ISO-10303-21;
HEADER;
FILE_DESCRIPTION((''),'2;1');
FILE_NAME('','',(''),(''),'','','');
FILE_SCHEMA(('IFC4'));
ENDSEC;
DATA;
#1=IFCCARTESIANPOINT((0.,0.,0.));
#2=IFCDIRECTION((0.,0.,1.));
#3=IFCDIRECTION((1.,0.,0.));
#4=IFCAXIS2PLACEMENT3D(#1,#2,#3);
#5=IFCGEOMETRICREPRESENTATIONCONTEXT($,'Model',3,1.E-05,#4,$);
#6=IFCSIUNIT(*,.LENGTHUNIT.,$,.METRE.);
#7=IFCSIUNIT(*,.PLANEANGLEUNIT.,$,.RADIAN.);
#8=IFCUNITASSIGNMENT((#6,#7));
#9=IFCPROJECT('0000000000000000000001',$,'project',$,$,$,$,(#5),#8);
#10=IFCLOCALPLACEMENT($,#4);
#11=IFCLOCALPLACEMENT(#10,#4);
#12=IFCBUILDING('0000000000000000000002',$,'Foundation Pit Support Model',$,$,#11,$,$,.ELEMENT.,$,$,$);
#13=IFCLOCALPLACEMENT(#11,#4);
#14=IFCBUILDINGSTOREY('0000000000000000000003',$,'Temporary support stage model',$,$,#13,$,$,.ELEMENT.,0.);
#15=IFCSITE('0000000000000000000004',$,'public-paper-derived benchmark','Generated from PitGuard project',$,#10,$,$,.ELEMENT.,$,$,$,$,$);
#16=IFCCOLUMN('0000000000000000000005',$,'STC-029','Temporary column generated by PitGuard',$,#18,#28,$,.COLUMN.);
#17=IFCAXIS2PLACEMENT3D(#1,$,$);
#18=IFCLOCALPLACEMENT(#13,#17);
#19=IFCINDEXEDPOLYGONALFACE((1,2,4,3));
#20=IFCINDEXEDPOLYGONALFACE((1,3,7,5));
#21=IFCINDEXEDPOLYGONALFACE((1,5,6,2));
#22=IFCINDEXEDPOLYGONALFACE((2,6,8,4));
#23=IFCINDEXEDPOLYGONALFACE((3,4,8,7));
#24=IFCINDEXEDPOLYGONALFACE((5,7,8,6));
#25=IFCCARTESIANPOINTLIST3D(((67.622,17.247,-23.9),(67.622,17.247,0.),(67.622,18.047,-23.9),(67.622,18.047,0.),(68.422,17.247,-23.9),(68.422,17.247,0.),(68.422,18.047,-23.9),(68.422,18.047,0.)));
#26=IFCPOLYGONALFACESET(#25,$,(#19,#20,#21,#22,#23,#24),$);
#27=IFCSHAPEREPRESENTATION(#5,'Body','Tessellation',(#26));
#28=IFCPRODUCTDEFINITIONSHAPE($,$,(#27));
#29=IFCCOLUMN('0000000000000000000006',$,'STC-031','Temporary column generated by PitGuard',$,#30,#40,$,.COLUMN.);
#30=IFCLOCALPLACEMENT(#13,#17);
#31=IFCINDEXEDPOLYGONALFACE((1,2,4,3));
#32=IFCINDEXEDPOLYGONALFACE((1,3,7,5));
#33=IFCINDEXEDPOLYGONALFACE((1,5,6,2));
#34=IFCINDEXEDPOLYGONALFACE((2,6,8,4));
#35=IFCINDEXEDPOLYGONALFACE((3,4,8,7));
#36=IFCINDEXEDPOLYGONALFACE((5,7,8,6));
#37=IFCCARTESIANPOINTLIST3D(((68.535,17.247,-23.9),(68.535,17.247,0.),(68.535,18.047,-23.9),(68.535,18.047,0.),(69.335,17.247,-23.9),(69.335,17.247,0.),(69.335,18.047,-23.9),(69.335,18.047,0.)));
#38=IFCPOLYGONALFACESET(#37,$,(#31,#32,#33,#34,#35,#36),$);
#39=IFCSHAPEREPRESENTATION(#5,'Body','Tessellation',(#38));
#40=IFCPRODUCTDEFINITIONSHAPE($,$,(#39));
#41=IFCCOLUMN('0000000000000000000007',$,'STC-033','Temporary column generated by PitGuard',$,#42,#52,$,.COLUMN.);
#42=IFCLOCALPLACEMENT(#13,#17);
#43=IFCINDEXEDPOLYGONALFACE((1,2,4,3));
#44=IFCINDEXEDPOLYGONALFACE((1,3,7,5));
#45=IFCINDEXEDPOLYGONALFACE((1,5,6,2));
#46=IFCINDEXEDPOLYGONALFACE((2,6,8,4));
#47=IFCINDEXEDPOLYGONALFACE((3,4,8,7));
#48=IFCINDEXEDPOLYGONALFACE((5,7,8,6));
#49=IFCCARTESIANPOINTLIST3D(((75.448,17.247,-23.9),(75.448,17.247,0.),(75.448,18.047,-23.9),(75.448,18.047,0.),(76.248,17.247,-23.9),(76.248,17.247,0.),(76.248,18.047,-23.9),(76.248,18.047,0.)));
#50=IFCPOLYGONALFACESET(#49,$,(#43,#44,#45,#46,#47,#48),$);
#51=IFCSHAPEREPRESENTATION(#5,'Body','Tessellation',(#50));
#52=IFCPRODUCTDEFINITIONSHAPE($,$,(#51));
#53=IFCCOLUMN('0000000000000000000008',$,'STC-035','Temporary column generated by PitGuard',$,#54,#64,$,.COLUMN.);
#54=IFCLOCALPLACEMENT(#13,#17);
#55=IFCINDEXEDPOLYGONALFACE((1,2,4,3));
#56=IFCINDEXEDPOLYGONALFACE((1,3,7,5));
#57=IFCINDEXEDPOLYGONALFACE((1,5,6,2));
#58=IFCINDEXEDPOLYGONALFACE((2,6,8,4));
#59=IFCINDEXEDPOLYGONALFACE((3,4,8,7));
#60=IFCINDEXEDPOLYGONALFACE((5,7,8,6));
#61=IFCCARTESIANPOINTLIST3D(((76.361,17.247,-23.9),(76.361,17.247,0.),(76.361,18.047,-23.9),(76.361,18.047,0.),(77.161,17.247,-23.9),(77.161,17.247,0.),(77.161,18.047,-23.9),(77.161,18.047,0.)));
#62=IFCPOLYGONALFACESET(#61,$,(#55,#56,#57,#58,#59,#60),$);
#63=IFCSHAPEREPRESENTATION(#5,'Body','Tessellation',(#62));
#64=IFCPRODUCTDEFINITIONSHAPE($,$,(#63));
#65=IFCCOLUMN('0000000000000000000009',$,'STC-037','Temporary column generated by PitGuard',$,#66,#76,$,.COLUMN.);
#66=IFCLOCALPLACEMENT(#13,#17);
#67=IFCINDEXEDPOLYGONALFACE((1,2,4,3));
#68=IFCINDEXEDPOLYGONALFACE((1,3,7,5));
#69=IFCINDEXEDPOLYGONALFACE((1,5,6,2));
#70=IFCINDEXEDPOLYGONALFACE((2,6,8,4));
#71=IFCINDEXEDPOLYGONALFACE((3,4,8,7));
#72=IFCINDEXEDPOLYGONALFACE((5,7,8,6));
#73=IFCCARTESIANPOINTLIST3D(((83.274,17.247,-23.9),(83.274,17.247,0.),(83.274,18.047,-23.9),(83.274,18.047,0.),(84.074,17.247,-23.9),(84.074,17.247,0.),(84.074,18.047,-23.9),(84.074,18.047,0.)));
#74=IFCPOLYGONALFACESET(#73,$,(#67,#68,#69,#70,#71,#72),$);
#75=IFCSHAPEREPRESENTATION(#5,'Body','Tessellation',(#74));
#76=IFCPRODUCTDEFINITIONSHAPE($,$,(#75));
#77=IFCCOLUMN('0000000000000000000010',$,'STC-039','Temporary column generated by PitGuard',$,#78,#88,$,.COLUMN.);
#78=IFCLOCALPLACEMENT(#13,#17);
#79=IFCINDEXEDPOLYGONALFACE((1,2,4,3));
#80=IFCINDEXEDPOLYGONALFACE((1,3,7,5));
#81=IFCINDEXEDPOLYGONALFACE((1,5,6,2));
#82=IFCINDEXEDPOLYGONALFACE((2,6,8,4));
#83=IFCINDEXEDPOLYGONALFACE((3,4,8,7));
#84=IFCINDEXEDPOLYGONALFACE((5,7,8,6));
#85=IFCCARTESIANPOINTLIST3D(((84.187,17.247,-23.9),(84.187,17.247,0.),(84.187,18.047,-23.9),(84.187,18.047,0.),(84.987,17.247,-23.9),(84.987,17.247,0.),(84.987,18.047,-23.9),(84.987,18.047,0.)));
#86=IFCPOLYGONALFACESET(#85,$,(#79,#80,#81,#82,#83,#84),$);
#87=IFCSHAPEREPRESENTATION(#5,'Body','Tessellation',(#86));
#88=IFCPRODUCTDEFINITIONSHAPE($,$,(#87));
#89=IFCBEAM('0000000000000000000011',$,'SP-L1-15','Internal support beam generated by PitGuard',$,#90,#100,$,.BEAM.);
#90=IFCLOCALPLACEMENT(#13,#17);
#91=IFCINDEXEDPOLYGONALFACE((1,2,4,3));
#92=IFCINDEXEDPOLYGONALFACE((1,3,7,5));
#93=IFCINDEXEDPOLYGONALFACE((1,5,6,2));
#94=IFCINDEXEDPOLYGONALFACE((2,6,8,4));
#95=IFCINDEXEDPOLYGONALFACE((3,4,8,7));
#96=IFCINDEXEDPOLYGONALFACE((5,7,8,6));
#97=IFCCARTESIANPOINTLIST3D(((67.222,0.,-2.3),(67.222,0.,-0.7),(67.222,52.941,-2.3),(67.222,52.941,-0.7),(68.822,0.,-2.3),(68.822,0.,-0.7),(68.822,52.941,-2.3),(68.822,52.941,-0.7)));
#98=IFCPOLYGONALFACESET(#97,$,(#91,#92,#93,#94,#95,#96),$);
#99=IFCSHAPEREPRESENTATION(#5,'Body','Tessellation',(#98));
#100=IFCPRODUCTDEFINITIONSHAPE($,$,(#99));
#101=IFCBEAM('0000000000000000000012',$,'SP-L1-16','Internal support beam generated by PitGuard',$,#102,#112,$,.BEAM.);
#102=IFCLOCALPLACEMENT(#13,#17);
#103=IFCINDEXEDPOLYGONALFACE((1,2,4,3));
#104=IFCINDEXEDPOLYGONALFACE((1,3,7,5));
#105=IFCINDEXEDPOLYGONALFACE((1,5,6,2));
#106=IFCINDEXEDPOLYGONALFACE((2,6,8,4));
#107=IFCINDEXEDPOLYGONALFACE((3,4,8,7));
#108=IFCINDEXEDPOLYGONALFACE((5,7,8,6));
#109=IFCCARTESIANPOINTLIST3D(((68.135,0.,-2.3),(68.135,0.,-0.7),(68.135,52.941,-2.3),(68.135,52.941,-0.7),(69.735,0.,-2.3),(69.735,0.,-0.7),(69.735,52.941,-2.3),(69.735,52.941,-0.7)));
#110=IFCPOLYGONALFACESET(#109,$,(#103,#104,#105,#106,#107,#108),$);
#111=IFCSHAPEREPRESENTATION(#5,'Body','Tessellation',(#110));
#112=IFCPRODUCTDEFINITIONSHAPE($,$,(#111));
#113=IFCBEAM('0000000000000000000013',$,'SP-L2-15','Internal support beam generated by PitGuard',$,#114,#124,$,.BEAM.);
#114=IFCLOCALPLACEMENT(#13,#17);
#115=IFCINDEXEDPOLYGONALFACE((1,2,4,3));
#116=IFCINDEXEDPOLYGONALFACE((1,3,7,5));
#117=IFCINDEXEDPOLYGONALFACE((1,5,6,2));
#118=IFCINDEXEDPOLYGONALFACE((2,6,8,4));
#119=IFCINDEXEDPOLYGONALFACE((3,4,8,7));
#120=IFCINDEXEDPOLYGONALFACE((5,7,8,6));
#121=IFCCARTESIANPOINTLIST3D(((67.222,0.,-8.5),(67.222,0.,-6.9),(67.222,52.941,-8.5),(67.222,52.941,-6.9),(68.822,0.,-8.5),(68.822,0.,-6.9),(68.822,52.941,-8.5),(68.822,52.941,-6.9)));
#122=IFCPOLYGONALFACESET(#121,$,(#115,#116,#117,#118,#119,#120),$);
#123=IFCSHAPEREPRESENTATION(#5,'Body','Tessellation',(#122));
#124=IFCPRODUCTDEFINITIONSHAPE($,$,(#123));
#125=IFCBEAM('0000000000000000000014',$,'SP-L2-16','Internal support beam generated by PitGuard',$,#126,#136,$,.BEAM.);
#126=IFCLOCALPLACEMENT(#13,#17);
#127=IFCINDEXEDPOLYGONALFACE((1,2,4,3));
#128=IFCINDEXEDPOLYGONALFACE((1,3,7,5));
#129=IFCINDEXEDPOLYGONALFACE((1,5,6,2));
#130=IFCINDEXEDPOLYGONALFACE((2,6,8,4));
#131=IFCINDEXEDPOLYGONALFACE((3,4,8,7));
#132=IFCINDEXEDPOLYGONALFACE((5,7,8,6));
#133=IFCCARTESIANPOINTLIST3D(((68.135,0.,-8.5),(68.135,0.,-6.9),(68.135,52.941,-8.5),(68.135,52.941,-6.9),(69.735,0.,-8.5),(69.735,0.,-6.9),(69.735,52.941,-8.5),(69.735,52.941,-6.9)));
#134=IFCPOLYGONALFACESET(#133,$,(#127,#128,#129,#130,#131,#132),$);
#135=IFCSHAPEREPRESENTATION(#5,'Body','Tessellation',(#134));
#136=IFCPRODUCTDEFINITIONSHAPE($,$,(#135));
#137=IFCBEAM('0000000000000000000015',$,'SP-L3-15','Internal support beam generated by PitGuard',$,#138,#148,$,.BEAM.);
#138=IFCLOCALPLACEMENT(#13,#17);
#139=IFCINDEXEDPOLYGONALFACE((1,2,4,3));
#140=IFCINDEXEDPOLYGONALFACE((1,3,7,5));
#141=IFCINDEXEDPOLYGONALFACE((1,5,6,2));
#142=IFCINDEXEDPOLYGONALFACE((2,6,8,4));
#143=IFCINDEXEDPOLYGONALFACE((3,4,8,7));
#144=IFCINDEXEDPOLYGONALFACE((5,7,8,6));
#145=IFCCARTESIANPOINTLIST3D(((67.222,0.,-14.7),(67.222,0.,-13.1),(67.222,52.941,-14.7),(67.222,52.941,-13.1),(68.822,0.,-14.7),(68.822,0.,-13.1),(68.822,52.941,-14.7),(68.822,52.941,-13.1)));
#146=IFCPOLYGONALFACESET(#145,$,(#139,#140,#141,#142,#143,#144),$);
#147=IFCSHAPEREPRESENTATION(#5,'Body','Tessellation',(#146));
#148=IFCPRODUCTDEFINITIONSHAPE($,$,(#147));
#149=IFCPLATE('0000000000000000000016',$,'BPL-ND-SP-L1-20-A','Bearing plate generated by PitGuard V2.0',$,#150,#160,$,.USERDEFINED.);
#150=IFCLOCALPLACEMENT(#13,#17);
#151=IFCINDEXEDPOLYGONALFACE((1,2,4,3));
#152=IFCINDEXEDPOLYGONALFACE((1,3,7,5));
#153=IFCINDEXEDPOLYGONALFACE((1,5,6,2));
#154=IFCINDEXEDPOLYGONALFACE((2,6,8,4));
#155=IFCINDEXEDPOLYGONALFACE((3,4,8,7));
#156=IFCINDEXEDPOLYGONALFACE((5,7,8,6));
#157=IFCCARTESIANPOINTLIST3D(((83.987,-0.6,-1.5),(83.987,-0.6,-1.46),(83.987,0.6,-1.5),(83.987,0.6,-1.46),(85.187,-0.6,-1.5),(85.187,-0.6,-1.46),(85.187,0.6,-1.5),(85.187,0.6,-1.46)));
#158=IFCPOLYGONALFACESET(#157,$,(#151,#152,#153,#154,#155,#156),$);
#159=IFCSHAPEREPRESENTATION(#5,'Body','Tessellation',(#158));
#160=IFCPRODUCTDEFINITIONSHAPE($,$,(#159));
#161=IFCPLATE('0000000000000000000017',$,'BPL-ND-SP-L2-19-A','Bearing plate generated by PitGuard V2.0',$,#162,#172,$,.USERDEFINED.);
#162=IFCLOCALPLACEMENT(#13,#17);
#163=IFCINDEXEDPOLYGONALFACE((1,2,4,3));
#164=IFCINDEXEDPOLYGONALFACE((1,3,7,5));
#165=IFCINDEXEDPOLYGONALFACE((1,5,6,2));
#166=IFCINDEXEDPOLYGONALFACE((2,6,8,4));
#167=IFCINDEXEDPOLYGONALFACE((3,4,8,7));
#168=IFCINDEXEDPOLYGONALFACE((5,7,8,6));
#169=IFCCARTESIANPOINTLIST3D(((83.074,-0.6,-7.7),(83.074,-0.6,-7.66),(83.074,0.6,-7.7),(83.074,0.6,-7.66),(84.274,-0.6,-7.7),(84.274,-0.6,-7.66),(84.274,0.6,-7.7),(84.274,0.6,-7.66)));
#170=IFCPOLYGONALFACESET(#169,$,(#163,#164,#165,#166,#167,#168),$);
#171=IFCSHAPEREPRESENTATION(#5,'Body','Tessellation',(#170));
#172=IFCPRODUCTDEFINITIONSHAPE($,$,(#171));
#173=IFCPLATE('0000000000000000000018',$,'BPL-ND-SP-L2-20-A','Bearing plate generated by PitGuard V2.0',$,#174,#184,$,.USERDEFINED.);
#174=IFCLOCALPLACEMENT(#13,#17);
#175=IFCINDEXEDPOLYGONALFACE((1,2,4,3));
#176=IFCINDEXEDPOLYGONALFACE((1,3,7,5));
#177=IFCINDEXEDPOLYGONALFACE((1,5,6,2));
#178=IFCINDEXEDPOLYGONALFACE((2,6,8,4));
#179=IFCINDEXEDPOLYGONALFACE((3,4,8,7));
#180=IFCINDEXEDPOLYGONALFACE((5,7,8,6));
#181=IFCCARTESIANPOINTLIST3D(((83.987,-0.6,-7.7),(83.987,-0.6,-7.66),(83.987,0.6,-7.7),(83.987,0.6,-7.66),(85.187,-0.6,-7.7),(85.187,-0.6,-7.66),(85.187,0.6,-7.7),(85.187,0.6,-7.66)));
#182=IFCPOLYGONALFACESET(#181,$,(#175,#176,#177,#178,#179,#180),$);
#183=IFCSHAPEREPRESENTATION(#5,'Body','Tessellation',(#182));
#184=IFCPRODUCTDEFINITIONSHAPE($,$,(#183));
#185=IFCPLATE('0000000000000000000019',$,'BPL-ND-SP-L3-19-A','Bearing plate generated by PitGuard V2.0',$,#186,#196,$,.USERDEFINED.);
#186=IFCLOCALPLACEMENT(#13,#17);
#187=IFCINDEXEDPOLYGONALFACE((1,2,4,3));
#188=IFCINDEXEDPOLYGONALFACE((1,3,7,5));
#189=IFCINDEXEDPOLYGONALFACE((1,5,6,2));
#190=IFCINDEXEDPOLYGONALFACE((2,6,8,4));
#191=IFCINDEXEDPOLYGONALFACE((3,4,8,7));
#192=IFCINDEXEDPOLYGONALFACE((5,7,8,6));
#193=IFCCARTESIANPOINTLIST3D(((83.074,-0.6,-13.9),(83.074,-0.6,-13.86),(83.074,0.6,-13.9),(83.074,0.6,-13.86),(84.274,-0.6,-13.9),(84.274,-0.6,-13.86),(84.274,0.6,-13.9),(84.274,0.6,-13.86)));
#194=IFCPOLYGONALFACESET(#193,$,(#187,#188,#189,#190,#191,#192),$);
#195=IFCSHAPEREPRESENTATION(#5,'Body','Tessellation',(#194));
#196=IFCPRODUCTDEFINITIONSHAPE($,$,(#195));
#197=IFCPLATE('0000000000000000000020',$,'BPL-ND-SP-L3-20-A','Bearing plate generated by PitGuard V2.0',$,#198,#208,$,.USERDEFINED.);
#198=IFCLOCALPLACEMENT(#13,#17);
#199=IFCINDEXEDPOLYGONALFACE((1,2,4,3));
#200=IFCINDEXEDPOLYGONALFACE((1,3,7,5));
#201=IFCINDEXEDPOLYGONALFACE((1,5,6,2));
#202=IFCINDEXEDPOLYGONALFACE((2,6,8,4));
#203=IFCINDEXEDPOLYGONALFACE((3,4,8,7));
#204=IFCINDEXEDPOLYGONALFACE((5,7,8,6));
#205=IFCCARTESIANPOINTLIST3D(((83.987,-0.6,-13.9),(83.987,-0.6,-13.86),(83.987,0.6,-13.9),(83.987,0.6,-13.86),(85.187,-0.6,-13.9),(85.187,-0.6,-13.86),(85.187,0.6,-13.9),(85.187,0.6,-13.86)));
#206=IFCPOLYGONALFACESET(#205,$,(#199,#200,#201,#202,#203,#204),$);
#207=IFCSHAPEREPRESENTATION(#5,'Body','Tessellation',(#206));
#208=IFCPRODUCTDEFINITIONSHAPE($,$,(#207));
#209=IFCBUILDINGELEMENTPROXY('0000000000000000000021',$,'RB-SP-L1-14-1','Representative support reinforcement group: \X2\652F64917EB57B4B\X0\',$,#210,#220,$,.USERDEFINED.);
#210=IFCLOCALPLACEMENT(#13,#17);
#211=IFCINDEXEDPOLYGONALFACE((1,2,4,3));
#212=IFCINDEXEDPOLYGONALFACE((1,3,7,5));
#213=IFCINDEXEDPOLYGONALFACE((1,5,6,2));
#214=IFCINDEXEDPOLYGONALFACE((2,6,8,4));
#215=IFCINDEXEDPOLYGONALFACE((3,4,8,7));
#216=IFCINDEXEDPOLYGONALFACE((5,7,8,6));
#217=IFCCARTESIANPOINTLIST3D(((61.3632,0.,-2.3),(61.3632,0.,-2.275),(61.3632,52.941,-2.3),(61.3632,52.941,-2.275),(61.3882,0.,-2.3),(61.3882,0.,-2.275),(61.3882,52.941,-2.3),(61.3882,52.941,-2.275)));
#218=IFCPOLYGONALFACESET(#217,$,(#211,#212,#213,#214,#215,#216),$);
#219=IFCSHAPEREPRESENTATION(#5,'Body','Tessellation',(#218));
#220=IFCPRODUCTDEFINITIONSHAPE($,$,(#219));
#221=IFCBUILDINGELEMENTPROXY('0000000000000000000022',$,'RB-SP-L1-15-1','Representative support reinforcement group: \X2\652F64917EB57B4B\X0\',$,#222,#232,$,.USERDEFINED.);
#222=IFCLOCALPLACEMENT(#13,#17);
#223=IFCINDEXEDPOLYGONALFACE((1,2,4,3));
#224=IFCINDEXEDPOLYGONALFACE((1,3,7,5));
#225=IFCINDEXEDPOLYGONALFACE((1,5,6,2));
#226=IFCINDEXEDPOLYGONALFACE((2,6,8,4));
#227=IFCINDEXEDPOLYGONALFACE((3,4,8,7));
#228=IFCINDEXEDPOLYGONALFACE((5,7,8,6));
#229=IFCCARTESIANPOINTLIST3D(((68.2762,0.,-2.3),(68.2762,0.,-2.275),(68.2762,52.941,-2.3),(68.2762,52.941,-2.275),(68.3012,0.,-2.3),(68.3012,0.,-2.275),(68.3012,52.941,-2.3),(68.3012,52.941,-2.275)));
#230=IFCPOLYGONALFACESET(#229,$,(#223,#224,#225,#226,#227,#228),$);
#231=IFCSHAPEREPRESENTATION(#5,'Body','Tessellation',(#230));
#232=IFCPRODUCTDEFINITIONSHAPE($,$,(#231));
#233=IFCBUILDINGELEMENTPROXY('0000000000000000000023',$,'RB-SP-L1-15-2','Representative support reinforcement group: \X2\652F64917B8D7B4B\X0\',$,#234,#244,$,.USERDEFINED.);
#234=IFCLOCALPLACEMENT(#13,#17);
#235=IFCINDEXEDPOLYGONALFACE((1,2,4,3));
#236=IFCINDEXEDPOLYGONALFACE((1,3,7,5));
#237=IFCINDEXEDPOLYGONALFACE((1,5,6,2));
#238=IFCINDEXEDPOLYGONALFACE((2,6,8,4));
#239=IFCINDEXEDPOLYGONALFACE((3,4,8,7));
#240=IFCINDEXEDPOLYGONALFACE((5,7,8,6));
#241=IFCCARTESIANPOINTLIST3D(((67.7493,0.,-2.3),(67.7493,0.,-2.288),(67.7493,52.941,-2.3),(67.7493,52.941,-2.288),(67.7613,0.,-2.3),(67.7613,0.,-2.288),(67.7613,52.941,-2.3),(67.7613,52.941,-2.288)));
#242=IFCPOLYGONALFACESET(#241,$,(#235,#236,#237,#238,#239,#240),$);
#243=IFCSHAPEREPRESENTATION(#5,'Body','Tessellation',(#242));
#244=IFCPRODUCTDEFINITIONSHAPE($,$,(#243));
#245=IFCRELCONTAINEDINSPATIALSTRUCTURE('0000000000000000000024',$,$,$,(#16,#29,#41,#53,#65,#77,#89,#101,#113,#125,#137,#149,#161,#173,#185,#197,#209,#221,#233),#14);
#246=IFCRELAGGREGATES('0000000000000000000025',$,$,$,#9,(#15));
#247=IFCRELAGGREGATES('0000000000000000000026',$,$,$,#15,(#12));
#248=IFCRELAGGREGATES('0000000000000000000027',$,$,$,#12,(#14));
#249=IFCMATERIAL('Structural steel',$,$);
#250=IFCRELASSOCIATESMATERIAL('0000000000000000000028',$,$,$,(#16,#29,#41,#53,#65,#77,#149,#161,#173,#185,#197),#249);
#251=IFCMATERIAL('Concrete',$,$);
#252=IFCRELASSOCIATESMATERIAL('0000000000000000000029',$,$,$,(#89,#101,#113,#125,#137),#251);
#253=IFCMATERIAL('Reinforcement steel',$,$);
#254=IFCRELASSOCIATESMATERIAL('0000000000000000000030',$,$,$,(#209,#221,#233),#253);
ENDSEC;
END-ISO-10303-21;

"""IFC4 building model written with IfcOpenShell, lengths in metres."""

from ifc_helpers import new_model, si_unit, frame, origin_with_axes, origin_2d, place, context, project, spatial, rectangle, extrude, material, element, save


model = new_model("IFC4")

# Units and contexts
model_context = context("Model", 3, precision=1e-05, world=origin_with_axes())
ifc_project = project(units=[si_unit("LENGTHUNIT", "METRE"), si_unit("PLANEANGLEUNIT", "RADIAN")], contexts=[model_context])

# Site, building, storey
site_placement = place(None, origin_with_axes())
site = spatial("IfcSite", under=ifc_project, at=site_placement, Name="public-paper-derived benchmark", Description="Generated from PitGuard project", CompositionType="ELEMENT")
building_placement = place(site_placement, origin_with_axes())
building = spatial("IfcBuilding", under=site, at=building_placement, Name="Foundation Pit Support Model", CompositionType="ELEMENT")
storey_placement = place(building_placement, origin_with_axes())
storey = spatial("IfcBuildingStorey", under=building, at=storey_placement, Name="Temporary support stage model", CompositionType="ELEMENT", Elevation=0.0)

# Columns
ifc_material_1 = material(Name="Structural steel")
for number, where, z_axis, x_axis, name in (
    (1, (68.022, 17.647, -23.9), (0.0, 0.0, 1.0), (1.0, 0.0, 0.0), "STC-029"),
    (2, (68.935, 17.647, -23.9), (0.0, 0.0, 1.0), (1.0, 0.0, 0.0), "STC-031"),
    (3, (75.848, 17.647, -23.9), (0.0, 0.0, 1.0), (1.0, 0.0, 0.0), "STC-033"),
    (4, (76.761, 17.647, -23.9), (0.0, 0.0, 1.0), (1.0, 0.0, 0.0), "STC-035"),
    (5, (83.674, 17.647, -23.9), (0.0, 0.0, 1.0), (1.0, 0.0, 0.0), "STC-037"),
    (6, (84.587, 17.647, -23.9), (0.0, 0.0, 1.0), (1.0, 0.0, 0.0), "STC-039"),
):
    element("IfcColumn", number, at=place(storey_placement, frame(where, z_axis=z_axis, x_axis=x_axis)), inside=storey, material=ifc_material_1, Name=name, Description="Temporary column generated by PitGuard", PredefinedType="COLUMN", context=model_context, shape_type="SweptSolid", body=[
        extrude(rectangle(XDim=0.8, YDim=0.8, at=origin_2d()), origin_with_axes(), (0.0, 0.0, 1.0), 23.9),
    ])

# Beams
ifc_material_2 = material(Name="Concrete")
for number, where, z_axis, x_axis, name in (
    (7, (68.022, 26.4705, -2.3), (0.0, 0.0, 1.0), (0.0, 1.0, 0.0), "SP-L1-15"),
    (8, (68.935, 26.4705, -2.3), (0.0, 0.0, 1.0), (0.0, 1.0, 0.0), "SP-L1-16"),
    (9, (68.022, 26.4705, -8.5), (0.0, 0.0, 1.0), (0.0, 1.0, 0.0), "SP-L2-15"),
    (10, (68.935, 26.4705, -8.5), (0.0, 0.0, 1.0), (0.0, 1.0, 0.0), "SP-L2-16"),
    (11, (68.022, 26.4705, -14.7), (0.0, 0.0, 1.0), (0.0, 1.0, 0.0), "SP-L3-15"),
):
    element("IfcBeam", number, at=place(storey_placement, frame(where, z_axis=z_axis, x_axis=x_axis)), inside=storey, material=ifc_material_2, Name=name, Description="Internal support beam generated by PitGuard", PredefinedType="BEAM", context=model_context, shape_type="SweptSolid", body=[
        extrude(rectangle(XDim=52.941, YDim=1.6, at=origin_2d()), origin_with_axes(), (0.0, 0.0, 1.0), 1.6),
    ])

# Plates
for number, where, z_axis, x_axis, name in (
    (12, (84.587, 0.0, -1.5), (0.0, 0.0, 1.0), (1.0, 0.0, 0.0), "BPL-ND-SP-L1-20-A"),
    (13, (83.674, 0.0, -7.7), (0.0, 0.0, 1.0), (1.0, 0.0, 0.0), "BPL-ND-SP-L2-19-A"),
    (14, (84.587, 0.0, -7.7), (0.0, 0.0, 1.0), (1.0, 0.0, 0.0), "BPL-ND-SP-L2-20-A"),
    (15, (83.674, 0.0, -13.9), (0.0, 0.0, 1.0), (1.0, 0.0, 0.0), "BPL-ND-SP-L3-19-A"),
    (16, (84.587, 0.0, -13.9), (0.0, 0.0, 1.0), (1.0, 0.0, 0.0), "BPL-ND-SP-L3-20-A"),
):
    element("IfcPlate", number, at=place(storey_placement, frame(where, z_axis=z_axis, x_axis=x_axis)), inside=storey, material=ifc_material_1, Name=name, Description="Bearing plate generated by PitGuard V2.0", PredefinedType="USERDEFINED", context=model_context, shape_type="SweptSolid", body=[
        extrude(rectangle(XDim=1.2, YDim=1.2, at=origin_2d()), origin_with_axes(), (0.0, 0.0, 1.0), 0.04),
    ])

# Building element proxies
ifc_material_3 = material(Name="Reinforcement steel")
for number, where, z_axis, x_axis, name in (
    (17, (61.3757, 26.4705, -2.3), (0.0, 0.0, 1.0), (0.0, 1.0, 0.0), "RB-SP-L1-14-1"),
    (18, (68.2887, 26.4705, -2.3), (0.0, 0.0, 1.0), (0.0, 1.0, 0.0), "RB-SP-L1-15-1"),
):
    element("IfcBuildingElementProxy", number, at=place(storey_placement, frame(where, z_axis=z_axis, x_axis=x_axis)), inside=storey, material=ifc_material_3, Name=name, Description="Representative support reinforcement group: 支撑纵筋", PredefinedType="USERDEFINED", context=model_context, shape_type="SweptSolid", body=[
        extrude(rectangle(XDim=52.941, YDim=0.025, at=origin_2d()), origin_with_axes(), (0.0, 0.0, 1.0), 0.025),
    ])
for number, where, z_axis, x_axis, name in (
    (19, (67.7553, 26.4705, -2.3), (0.0, 0.0, 1.0), (0.0, 1.0, 0.0), "RB-SP-L1-15-2"),
):
    element("IfcBuildingElementProxy", number, at=place(storey_placement, frame(where, z_axis=z_axis, x_axis=x_axis)), inside=storey, material=ifc_material_3, Name=name, Description="Representative support reinforcement group: 支撑箍筋", PredefinedType="USERDEFINED", context=model_context, shape_type="SweptSolid", body=[
        extrude(rectangle(XDim=52.941, YDim=0.012, at=origin_2d()), origin_with_axes(), (0.0, 0.0, 1.0), 0.012),
    ])

save(model, "model.ifc")
